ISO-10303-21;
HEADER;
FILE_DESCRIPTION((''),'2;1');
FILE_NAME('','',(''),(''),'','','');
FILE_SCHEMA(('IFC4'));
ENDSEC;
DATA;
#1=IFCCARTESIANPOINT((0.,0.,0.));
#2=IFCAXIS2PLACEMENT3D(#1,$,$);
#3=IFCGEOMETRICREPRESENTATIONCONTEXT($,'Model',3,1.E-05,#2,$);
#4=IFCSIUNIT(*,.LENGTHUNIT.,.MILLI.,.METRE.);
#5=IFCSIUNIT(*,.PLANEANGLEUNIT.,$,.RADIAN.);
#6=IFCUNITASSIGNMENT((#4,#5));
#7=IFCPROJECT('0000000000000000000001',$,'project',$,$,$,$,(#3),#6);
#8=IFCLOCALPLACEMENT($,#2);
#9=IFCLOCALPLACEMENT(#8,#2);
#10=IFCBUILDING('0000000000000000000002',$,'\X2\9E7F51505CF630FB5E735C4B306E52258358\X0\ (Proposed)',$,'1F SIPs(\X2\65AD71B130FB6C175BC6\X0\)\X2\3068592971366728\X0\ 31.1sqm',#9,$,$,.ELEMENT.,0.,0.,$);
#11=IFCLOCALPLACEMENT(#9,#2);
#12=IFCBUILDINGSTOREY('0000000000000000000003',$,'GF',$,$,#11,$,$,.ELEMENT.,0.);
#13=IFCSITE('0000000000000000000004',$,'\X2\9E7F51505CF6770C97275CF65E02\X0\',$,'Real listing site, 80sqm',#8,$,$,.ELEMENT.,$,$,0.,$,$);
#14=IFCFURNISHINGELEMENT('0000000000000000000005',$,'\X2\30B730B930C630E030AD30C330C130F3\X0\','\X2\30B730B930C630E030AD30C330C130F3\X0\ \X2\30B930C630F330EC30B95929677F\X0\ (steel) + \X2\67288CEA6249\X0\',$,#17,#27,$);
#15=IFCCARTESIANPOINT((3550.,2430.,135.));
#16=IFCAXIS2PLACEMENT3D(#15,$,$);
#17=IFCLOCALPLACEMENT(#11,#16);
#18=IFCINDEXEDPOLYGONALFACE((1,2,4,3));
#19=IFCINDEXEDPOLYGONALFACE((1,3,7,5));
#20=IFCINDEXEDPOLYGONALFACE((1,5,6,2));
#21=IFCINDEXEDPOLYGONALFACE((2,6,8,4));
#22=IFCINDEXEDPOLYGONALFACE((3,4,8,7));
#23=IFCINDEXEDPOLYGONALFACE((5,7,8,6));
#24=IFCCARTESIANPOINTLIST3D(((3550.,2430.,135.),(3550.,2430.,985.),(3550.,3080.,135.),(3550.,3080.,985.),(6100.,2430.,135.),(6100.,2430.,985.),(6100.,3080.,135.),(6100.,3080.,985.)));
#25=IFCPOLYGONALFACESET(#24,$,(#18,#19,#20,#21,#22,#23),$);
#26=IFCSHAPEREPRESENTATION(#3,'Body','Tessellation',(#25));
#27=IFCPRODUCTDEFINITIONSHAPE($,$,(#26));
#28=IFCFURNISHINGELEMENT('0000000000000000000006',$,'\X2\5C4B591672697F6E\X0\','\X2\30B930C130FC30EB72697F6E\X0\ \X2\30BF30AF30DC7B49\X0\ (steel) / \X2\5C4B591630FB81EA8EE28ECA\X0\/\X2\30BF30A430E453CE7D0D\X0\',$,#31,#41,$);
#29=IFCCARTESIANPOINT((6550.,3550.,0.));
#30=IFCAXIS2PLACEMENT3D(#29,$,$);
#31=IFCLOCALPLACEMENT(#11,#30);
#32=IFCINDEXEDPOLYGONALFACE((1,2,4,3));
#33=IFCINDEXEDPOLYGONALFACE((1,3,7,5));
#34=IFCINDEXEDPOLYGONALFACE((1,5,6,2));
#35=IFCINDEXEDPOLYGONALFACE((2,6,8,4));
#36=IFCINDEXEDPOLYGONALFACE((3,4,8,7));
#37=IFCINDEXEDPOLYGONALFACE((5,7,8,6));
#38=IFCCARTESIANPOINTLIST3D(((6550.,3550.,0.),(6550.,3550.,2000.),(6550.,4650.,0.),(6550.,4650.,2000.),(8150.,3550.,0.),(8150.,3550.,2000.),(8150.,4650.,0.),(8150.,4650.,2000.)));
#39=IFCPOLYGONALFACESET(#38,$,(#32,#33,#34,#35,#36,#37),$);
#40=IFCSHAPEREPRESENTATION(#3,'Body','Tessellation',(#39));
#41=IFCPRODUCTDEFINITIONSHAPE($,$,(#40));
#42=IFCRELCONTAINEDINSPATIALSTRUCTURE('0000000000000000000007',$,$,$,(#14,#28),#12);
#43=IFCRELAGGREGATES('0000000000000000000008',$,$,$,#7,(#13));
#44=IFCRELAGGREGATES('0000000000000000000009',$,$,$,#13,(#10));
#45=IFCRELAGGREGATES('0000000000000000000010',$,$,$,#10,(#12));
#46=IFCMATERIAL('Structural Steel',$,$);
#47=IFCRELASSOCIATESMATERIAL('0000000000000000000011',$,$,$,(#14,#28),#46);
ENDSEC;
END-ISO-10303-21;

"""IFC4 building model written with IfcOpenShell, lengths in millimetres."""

from ifc_helpers import new_model, si_unit, frame, frame_2d, origin, place, context, project, spatial, rectangle, extrude, material, element, save


model = new_model("IFC4")

# Units and contexts
model_context = context("Model", 3, precision=1e-05, world=origin())
ifc_project = project(units=[si_unit("LENGTHUNIT", "METRE", prefix="MILLI"), si_unit("PLANEANGLEUNIT", "RADIAN")], contexts=[model_context])

# Site, building, storey
site_placement = place(None, origin())
site = spatial("IfcSite", under=ifc_project, at=site_placement, Name="鹿児島県霧島市", ObjectType="Real listing site, 80sqm", CompositionType="ELEMENT", RefElevation=0.0)
building_placement = place(site_placement, origin())
building = spatial("IfcBuilding", under=site, at=building_placement, Name="鹿児島・平屋の別荘 (Proposed)", ObjectType="1F SIPs(断熱・気密)と天然木 31.1sqm", CompositionType="ELEMENT", ElevationOfRefHeight=0.0, ElevationOfTerrain=0.0)
storey_placement = place(building_placement, origin())
storey = spatial("IfcBuildingStorey", under=building, at=storey_placement, Name="GF", CompositionType="ELEMENT", Elevation=0.0)

# Shared definitions
ifc_material_1 = material(Name="Structural Steel")

# Furnishing elements
furnishing_1_placement = place(storey_placement, frame((3550.0, 2430.0, 135.0)))
element("IfcFurnishingElement", 1, at=furnishing_1_placement, inside=storey, material=ifc_material_1, Name="システムキッチン", Description="システムキッチン ステンレス天板 (steel) + 木質扉", context=model_context, shape_type="SweptSolid", body=[
    extrude(rectangle(XDim=2550.0, YDim=650.0, at=frame_2d((1275.0, 325.0))), frame((3550.0, 2430.0, 135.0)), (0.0, 0.0, 1.0), 850.0),
])
furnishing_2_placement = place(storey_placement, frame((6550.0, 3550.0, 0.0)))
element("IfcFurnishingElement", 2, at=furnishing_2_placement, inside=storey, material=ifc_material_1, Name="屋外物置", Description="スチール物置 タクボ等 (steel) / 屋外・自転車/タイヤ収納", context=model_context, shape_type="SweptSolid", body=[
    extrude(rectangle(XDim=1600.0, YDim=1100.0, at=frame_2d((800.0, 550.0))), frame((6550.0, 3550.0, 0.0)), (0.0, 0.0, 1.0), 2000.0),
])

save(model, "model.ifc")
